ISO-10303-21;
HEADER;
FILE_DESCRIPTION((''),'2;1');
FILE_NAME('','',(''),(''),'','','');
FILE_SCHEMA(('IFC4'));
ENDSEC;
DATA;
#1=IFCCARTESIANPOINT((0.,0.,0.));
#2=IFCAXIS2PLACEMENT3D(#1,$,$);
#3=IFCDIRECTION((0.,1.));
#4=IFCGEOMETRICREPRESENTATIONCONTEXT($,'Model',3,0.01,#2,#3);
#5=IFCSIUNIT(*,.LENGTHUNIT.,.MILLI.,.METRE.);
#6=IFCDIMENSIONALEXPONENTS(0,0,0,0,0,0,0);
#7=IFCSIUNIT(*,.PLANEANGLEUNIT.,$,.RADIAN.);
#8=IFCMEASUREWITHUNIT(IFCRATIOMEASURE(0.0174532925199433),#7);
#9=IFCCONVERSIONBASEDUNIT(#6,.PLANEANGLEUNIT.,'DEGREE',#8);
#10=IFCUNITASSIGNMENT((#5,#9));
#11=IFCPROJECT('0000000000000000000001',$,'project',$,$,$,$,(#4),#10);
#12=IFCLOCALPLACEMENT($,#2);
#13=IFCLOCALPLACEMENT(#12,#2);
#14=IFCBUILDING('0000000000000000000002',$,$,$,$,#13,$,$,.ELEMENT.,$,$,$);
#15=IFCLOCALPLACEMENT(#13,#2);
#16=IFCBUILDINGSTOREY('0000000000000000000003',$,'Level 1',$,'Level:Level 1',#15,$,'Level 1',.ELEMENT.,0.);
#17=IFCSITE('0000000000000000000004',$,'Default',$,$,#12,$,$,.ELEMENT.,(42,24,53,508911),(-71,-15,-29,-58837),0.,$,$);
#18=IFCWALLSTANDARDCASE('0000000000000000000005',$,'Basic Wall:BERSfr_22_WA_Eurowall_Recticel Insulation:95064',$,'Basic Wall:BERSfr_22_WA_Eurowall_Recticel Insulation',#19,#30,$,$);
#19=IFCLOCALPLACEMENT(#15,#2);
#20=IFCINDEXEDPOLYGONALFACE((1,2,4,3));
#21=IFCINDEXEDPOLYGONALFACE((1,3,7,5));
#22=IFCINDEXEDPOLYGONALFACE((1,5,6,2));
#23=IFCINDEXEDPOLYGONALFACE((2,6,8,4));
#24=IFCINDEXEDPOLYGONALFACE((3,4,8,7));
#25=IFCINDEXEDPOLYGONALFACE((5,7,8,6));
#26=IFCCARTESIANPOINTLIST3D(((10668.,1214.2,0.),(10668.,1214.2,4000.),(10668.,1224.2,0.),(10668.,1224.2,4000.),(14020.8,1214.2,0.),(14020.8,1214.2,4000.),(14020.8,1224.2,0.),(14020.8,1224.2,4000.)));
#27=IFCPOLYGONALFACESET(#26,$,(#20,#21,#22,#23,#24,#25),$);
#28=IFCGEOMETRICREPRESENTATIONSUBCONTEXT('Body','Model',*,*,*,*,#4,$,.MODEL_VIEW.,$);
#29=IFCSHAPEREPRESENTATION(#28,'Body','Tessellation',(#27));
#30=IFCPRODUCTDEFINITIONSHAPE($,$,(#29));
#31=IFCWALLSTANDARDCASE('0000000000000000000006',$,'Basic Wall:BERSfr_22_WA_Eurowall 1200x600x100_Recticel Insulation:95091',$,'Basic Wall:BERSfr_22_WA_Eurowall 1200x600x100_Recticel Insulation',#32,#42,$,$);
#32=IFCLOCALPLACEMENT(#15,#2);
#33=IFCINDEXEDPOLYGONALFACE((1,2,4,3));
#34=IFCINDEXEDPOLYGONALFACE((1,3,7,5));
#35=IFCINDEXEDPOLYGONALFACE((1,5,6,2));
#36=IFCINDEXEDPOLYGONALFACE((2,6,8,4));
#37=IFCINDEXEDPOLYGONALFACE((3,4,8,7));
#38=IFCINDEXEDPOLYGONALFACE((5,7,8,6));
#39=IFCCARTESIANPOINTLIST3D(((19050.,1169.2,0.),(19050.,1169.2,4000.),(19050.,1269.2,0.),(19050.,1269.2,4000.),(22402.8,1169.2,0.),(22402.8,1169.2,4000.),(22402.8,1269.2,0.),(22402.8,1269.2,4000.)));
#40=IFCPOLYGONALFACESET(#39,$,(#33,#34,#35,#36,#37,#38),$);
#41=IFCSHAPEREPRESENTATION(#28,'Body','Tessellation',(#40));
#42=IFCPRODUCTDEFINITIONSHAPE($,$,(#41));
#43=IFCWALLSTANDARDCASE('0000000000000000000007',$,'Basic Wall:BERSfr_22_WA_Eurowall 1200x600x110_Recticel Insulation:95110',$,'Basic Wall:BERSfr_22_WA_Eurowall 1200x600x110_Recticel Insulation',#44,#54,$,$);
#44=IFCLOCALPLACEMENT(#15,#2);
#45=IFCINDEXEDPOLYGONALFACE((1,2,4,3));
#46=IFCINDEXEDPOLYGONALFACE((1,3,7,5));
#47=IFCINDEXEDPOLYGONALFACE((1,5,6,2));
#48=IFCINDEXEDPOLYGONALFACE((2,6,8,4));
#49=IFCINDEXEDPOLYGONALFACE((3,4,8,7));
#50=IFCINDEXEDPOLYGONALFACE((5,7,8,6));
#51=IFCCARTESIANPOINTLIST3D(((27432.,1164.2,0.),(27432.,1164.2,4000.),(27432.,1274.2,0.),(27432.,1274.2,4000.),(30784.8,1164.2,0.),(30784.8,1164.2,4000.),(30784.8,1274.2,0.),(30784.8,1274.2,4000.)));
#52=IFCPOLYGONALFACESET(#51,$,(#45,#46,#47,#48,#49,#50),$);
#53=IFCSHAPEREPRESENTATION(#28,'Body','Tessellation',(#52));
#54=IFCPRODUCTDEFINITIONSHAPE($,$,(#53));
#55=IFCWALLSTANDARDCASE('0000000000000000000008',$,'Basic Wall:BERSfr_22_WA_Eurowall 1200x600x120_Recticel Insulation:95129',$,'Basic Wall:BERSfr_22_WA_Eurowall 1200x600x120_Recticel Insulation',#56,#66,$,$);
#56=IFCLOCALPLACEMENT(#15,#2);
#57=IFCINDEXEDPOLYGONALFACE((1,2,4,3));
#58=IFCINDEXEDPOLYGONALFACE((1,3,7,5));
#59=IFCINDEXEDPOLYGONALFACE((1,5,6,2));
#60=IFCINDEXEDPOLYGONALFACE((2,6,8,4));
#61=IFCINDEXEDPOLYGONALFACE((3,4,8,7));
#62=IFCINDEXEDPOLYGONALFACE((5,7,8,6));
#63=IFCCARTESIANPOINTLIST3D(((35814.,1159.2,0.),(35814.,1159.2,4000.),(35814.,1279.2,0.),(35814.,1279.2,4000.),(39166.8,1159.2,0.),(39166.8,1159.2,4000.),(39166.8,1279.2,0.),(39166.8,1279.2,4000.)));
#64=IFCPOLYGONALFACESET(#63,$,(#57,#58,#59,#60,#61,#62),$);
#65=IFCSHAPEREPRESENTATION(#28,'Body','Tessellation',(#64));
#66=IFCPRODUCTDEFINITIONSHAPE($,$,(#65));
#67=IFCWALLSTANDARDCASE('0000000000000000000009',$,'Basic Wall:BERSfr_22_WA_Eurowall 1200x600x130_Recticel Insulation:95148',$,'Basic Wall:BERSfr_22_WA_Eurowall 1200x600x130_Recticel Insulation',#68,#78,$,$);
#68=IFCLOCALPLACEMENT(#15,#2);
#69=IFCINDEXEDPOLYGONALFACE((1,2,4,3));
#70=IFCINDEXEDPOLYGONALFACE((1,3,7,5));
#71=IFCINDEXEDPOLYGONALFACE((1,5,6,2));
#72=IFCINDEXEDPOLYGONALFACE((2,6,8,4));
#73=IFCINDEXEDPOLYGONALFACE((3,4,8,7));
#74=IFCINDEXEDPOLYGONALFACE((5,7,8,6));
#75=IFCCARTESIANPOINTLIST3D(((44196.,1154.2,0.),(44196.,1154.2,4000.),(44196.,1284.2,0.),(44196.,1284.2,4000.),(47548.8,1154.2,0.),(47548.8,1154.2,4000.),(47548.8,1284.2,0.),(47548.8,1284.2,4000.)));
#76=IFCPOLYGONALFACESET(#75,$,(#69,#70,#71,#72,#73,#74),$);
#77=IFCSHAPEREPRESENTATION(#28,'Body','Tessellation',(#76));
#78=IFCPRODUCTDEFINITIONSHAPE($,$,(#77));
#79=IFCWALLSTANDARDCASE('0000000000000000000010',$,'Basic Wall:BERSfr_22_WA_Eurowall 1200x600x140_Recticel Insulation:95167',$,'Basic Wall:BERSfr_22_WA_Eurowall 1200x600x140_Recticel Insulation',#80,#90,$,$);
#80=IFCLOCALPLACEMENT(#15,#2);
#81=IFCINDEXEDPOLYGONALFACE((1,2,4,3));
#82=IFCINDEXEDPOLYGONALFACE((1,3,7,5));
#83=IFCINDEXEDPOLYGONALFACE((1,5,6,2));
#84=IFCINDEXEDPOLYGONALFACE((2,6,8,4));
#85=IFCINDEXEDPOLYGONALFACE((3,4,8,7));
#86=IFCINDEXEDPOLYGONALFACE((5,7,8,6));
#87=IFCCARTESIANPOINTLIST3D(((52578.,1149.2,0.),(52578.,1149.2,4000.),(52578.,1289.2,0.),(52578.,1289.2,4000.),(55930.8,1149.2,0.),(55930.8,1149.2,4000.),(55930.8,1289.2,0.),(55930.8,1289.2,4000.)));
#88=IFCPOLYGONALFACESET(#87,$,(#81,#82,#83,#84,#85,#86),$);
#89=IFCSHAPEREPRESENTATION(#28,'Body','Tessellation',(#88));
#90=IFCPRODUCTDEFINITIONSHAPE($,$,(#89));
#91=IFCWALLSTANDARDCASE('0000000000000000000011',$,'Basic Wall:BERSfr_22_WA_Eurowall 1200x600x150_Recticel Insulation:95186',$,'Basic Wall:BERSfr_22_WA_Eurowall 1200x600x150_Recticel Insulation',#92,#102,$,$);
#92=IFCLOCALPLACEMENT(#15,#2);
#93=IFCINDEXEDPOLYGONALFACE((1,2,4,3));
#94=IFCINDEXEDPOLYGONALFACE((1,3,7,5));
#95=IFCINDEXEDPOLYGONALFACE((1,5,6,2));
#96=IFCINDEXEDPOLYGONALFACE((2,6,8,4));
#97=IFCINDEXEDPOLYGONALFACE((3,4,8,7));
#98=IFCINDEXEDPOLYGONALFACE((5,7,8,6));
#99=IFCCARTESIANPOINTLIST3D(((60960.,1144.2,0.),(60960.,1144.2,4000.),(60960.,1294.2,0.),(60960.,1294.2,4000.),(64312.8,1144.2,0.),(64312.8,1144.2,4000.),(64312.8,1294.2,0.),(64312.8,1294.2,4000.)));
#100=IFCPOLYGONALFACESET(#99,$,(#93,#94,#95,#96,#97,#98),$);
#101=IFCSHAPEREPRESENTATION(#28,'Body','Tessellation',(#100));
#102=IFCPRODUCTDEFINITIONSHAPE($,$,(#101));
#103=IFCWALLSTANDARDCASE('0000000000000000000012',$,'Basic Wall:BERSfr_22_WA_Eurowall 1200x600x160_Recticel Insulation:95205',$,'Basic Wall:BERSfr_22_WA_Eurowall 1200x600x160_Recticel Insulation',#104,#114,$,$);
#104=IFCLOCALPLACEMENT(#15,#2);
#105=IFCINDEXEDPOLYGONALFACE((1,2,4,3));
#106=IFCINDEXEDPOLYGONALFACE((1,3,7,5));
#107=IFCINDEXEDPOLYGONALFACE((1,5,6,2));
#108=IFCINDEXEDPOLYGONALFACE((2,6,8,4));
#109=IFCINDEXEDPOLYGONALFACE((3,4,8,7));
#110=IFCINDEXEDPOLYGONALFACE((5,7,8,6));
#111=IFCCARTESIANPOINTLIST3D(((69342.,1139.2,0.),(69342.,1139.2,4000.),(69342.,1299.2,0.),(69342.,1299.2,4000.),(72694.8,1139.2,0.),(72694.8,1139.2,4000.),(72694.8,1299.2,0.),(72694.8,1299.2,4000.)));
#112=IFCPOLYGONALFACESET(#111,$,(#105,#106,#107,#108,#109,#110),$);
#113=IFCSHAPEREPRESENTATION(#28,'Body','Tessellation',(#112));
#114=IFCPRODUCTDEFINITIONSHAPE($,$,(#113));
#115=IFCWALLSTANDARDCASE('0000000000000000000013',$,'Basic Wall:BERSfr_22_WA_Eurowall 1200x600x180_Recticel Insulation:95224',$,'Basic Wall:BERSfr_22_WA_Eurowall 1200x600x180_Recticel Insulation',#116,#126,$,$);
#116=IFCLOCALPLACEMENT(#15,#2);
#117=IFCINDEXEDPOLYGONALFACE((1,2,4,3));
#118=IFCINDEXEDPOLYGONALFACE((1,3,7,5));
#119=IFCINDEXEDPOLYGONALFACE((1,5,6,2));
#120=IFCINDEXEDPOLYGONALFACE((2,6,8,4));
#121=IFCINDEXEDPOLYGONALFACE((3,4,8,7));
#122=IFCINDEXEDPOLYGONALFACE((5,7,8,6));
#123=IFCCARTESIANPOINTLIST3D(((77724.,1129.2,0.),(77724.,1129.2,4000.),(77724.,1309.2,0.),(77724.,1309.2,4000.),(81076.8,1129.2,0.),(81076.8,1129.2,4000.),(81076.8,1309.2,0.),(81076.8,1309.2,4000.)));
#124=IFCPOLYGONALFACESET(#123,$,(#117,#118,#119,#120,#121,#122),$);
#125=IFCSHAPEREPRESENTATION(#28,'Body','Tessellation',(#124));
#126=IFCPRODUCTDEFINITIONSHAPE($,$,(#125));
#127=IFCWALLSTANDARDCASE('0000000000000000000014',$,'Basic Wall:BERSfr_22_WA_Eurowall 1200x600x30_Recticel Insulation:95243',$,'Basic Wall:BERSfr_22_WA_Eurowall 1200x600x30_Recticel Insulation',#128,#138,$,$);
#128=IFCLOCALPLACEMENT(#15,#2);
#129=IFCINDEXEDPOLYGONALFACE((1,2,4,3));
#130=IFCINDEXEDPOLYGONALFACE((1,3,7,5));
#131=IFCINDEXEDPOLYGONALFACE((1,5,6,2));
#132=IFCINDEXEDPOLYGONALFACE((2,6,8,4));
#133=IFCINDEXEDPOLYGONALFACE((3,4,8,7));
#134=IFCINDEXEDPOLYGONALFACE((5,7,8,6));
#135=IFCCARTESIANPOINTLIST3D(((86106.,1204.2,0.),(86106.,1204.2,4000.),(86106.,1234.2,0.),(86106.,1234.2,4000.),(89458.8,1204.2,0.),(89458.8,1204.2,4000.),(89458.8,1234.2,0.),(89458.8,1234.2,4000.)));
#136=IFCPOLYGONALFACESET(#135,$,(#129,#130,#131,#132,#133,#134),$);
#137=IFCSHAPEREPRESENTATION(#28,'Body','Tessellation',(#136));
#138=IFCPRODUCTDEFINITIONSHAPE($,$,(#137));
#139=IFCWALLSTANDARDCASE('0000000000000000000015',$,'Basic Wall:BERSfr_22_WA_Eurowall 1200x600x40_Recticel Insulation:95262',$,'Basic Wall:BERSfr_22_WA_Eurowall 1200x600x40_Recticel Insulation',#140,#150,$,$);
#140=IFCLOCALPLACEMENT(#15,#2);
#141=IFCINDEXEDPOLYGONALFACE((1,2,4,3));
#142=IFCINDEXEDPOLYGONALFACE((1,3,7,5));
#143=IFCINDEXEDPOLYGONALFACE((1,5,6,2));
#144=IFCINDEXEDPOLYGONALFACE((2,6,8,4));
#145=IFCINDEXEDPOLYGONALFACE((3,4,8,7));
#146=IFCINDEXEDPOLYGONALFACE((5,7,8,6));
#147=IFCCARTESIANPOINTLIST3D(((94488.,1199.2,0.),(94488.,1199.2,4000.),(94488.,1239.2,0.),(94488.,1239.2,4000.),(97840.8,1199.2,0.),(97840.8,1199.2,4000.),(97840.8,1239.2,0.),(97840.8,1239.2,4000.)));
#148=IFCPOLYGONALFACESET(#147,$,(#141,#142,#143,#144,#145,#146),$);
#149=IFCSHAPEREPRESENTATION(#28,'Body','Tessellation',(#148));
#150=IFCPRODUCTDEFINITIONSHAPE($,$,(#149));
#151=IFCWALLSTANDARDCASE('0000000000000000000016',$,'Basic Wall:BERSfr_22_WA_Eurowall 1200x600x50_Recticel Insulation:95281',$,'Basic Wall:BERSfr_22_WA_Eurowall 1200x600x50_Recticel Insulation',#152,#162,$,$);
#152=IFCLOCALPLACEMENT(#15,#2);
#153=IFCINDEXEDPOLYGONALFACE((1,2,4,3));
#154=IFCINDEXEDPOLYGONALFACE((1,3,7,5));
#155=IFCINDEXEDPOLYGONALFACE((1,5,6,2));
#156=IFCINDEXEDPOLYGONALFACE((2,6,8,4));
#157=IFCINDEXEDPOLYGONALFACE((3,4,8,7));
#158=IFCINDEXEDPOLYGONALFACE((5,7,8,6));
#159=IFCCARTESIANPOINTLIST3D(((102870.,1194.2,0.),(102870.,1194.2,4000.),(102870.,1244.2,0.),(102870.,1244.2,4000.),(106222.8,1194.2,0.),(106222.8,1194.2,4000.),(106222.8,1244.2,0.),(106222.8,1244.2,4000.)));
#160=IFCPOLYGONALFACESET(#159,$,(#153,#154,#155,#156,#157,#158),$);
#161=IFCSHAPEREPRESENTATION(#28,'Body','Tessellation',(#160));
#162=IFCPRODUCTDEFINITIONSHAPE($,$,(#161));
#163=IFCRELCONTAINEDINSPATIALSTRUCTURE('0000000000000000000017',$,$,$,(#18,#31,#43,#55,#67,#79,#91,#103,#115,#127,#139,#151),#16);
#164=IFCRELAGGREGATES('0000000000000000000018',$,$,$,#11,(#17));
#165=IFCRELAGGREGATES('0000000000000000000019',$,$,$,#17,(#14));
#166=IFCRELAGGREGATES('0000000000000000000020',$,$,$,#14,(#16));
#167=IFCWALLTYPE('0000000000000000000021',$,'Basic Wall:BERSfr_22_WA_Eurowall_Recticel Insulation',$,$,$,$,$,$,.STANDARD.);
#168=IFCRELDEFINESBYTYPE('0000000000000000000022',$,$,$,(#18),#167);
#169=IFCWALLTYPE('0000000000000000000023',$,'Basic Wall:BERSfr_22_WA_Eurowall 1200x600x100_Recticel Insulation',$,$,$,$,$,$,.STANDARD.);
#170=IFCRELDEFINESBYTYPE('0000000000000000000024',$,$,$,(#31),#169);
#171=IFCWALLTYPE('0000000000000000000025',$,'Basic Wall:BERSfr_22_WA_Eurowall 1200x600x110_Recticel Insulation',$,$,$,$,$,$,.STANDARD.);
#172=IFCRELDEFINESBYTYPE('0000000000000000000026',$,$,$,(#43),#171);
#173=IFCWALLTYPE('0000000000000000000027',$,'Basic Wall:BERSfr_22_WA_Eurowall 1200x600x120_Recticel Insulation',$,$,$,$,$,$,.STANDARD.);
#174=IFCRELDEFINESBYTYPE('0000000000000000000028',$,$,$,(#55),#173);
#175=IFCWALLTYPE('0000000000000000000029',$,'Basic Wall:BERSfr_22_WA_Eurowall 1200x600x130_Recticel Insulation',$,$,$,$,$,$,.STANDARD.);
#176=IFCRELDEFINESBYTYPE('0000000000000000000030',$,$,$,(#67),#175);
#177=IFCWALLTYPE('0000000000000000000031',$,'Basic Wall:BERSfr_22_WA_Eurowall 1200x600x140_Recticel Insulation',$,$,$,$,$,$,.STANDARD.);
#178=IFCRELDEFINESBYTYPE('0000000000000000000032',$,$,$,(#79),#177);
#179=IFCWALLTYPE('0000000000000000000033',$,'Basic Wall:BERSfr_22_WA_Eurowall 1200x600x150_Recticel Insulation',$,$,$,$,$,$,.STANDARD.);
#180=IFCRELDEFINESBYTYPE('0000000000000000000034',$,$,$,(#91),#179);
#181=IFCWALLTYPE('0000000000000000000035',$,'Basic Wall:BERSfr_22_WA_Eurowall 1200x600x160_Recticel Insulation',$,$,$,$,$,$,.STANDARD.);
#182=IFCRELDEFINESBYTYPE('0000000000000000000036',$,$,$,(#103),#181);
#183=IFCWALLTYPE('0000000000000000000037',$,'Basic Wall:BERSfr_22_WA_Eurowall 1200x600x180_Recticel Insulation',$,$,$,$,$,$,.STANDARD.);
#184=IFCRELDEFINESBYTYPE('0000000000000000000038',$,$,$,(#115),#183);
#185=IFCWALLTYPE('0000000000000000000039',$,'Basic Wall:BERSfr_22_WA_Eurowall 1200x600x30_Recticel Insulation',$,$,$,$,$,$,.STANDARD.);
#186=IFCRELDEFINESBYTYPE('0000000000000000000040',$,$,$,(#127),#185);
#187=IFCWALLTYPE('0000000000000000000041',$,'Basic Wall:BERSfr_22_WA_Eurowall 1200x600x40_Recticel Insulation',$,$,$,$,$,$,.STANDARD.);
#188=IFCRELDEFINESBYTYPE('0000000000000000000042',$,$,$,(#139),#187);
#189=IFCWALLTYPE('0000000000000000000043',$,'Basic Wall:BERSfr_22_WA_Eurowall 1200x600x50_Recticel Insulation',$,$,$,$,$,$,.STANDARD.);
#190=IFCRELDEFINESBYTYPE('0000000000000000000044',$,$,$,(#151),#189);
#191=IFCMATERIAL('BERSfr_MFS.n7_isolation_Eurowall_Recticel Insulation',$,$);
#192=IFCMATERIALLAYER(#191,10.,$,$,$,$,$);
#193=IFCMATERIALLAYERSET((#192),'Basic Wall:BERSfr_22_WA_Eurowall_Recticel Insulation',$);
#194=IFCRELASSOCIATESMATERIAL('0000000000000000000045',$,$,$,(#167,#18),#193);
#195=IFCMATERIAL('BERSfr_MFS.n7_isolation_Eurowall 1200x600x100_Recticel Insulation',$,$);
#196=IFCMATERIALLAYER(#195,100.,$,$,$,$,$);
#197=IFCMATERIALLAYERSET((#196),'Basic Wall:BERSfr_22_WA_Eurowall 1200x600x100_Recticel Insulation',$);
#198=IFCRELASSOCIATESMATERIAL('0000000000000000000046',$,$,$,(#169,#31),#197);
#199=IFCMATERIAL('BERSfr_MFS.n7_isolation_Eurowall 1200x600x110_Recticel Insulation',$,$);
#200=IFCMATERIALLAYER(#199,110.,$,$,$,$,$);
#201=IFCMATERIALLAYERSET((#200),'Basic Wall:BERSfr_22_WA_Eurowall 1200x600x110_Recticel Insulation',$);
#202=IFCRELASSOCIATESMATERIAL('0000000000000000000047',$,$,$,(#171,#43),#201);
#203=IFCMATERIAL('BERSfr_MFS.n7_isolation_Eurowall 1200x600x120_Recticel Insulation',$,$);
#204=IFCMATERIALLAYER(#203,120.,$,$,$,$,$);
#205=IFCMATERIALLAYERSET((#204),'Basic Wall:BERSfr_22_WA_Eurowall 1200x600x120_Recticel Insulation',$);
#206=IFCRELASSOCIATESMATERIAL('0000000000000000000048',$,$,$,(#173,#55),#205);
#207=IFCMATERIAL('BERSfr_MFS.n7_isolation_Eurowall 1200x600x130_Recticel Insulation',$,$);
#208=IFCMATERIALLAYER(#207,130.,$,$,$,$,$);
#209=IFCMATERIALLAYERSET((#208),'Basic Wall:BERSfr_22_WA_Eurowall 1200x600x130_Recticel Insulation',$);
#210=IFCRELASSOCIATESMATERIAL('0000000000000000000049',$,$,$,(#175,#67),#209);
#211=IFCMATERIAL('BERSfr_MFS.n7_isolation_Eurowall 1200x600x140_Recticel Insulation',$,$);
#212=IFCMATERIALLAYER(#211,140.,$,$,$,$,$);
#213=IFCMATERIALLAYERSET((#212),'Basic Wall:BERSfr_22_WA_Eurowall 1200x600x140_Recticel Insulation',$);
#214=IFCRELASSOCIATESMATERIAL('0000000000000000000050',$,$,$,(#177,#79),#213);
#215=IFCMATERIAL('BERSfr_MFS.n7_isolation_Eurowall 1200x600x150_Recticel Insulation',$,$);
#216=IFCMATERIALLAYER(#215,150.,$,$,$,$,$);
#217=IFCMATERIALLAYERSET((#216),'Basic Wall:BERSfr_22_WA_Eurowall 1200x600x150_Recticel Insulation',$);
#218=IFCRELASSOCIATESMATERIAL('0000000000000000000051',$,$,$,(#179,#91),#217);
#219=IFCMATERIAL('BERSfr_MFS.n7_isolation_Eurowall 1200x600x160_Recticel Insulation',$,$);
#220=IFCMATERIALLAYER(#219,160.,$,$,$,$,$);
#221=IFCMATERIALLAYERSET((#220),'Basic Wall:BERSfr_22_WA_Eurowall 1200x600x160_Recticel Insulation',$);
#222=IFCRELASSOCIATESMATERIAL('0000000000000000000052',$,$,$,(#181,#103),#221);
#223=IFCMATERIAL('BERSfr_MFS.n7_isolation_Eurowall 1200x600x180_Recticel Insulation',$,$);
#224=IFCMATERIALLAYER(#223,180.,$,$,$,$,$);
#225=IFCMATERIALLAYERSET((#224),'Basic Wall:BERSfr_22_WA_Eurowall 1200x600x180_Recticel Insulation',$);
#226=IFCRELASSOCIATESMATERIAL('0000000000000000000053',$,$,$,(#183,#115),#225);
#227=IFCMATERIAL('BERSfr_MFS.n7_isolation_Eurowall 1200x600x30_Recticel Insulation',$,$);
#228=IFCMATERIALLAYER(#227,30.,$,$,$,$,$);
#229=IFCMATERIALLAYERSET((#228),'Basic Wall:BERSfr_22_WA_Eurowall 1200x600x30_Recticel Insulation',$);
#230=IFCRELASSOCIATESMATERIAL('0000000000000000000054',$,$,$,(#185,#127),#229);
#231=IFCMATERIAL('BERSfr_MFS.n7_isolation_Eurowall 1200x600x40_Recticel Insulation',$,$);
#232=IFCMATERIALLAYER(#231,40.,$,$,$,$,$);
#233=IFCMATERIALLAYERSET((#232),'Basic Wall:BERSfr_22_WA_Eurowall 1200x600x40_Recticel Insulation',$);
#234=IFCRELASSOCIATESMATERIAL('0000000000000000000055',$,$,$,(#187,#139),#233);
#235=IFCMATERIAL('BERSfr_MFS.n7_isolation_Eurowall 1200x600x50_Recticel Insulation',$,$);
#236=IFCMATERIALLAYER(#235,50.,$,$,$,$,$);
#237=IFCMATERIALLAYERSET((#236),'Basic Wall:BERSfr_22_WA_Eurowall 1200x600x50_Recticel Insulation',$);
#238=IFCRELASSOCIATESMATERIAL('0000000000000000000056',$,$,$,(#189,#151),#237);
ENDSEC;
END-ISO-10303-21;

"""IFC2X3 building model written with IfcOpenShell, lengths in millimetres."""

from ifc_helpers import new_model, entity, si_unit, converted_unit, direction, frame, frame_2d, origin, place, context, subcontext, project, spatial, rectangle, extrude, material, layer, layer_set, layer_usage, type_object, element, save


model = new_model("IFC2X3")

# Units and contexts
model_context = context("Model", 3, precision=0.01, world=origin(), true_north=direction((0.0, 1.0)))
body_context = subcontext(model_context, "Body", "Model", "MODEL_VIEW")
ifc_project = project(units=[si_unit("LENGTHUNIT", "METRE", prefix="MILLI"), converted_unit("PLANEANGLEUNIT", "DEGREE", entity("IfcRatioMeasure", 0.0174532925199433), si_unit("PLANEANGLEUNIT", "RADIAN"), dimensions=[0, 0, 0, 0, 0, 0, 0])], contexts=[model_context])

# Site, building, storey
site_placement = place(None, origin())
site = spatial("IfcSite", under=ifc_project, at=site_placement, Name="Default", CompositionType="ELEMENT", RefLatitude=(42, 24, 53, 508911), RefLongitude=(-71, -15, -29, -58837), RefElevation=0.0)
building_placement = place(site_placement, origin())
building = spatial("IfcBuilding", under=site, at=building_placement, CompositionType="ELEMENT")
storey_placement = place(building_placement, origin())
storey = spatial("IfcBuildingStorey", under=building, at=storey_placement, Name="Level 1", ObjectType="Level:Level 1", LongName="Level 1", CompositionType="ELEMENT", Elevation=0.0)

# Walls
ifc_material_1 = material(Name="BERSfr_MFS.n7_isolation_Eurowall_Recticel Insulation")
ifc_layer_1 = layer(ifc_material_1, 10.0)
ifc_layer_set_1 = layer_set([ifc_layer_1], Name="Basic Wall:BERSfr_22_WA_Eurowall_Recticel Insulation")
ifc_layer_usage_1 = layer_usage(ifc_layer_set_1, "AXIS2", "NEGATIVE", 5.0)
wall_type_1 = type_object("IfcWallType", Name="Basic Wall:BERSfr_22_WA_Eurowall_Recticel Insulation", PredefinedType="STANDARD", material=ifc_layer_set_1)
wall_1_placement = place(storey_placement, frame((10668.0, 1219.2, 0.0)))
element("IfcWallStandardCase", 1, at=wall_1_placement, inside=storey, type_object=wall_type_1, material=ifc_layer_usage_1, Name="Basic Wall:BERSfr_22_WA_Eurowall_Recticel Insulation:95064", ObjectType="Basic Wall:BERSfr_22_WA_Eurowall_Recticel Insulation", context=body_context, shape_type="SweptSolid", body=[
    extrude(rectangle(XDim=3352.8, YDim=10.0, at=frame_2d((1676.4, 0.0), x_axis=(-1.0, 0.0))), origin(), (0.0, 0.0, 1.0), 4000.0),
])
ifc_material_2 = material(Name="BERSfr_MFS.n7_isolation_Eurowall 1200x600x100_Recticel Insulation")
ifc_layer_2 = layer(ifc_material_2, 100.0)
ifc_layer_set_2 = layer_set([ifc_layer_2], Name="Basic Wall:BERSfr_22_WA_Eurowall 1200x600x100_Recticel Insulation")
ifc_layer_usage_2 = layer_usage(ifc_layer_set_2, "AXIS2", "NEGATIVE", 50.0)
wall_type_2 = type_object("IfcWallType", Name="Basic Wall:BERSfr_22_WA_Eurowall 1200x600x100_Recticel Insulation", PredefinedType="STANDARD", material=ifc_layer_set_2)
wall_2_placement = place(storey_placement, frame((19050.0, 1219.2, 0.0)))
element("IfcWallStandardCase", 2, at=wall_2_placement, inside=storey, type_object=wall_type_2, material=ifc_layer_usage_2, Name="Basic Wall:BERSfr_22_WA_Eurowall 1200x600x100_Recticel Insulation:95091", ObjectType="Basic Wall:BERSfr_22_WA_Eurowall 1200x600x100_Recticel Insulation", context=body_context, shape_type="SweptSolid", body=[
    extrude(rectangle(XDim=3352.8, YDim=100.0, at=frame_2d((1676.4, 0.0), x_axis=(-1.0, 0.0))), origin(), (0.0, 0.0, 1.0), 4000.0),
])
ifc_material_3 = material(Name="BERSfr_MFS.n7_isolation_Eurowall 1200x600x110_Recticel Insulation")
ifc_layer_3 = layer(ifc_material_3, 110.0)
ifc_layer_set_3 = layer_set([ifc_layer_3], Name="Basic Wall:BERSfr_22_WA_Eurowall 1200x600x110_Recticel Insulation")
ifc_layer_usage_3 = layer_usage(ifc_layer_set_3, "AXIS2", "NEGATIVE", 55.0)
wall_type_3 = type_object("IfcWallType", Name="Basic Wall:BERSfr_22_WA_Eurowall 1200x600x110_Recticel Insulation", PredefinedType="STANDARD", material=ifc_layer_set_3)
wall_3_placement = place(storey_placement, frame((27432.0, 1219.2, 0.0)))
element("IfcWallStandardCase", 3, at=wall_3_placement, inside=storey, type_object=wall_type_3, material=ifc_layer_usage_3, Name="Basic Wall:BERSfr_22_WA_Eurowall 1200x600x110_Recticel Insulation:95110", ObjectType="Basic Wall:BERSfr_22_WA_Eurowall 1200x600x110_Recticel Insulation", context=body_context, shape_type="SweptSolid", body=[
    extrude(rectangle(XDim=3352.8, YDim=110.0, at=frame_2d((1676.4, 0.0), x_axis=(-1.0, 0.0))), origin(), (0.0, 0.0, 1.0), 4000.0),
])
ifc_material_4 = material(Name="BERSfr_MFS.n7_isolation_Eurowall 1200x600x120_Recticel Insulation")
ifc_layer_4 = layer(ifc_material_4, 120.0)
ifc_layer_set_4 = layer_set([ifc_layer_4], Name="Basic Wall:BERSfr_22_WA_Eurowall 1200x600x120_Recticel Insulation")
ifc_layer_usage_4 = layer_usage(ifc_layer_set_4, "AXIS2", "NEGATIVE", 60.0)
wall_type_4 = type_object("IfcWallType", Name="Basic Wall:BERSfr_22_WA_Eurowall 1200x600x120_Recticel Insulation", PredefinedType="STANDARD", material=ifc_layer_set_4)
wall_4_placement = place(storey_placement, frame((35814.0, 1219.2, 0.0)))
element("IfcWallStandardCase", 4, at=wall_4_placement, inside=storey, type_object=wall_type_4, material=ifc_layer_usage_4, Name="Basic Wall:BERSfr_22_WA_Eurowall 1200x600x120_Recticel Insulation:95129", ObjectType="Basic Wall:BERSfr_22_WA_Eurowall 1200x600x120_Recticel Insulation", context=body_context, shape_type="SweptSolid", body=[
    extrude(rectangle(XDim=3352.8, YDim=120.0, at=frame_2d((1676.4, 0.0), x_axis=(-1.0, 0.0))), origin(), (0.0, 0.0, 1.0), 4000.0),
])
ifc_material_5 = material(Name="BERSfr_MFS.n7_isolation_Eurowall 1200x600x130_Recticel Insulation")
ifc_layer_5 = layer(ifc_material_5, 130.0)
ifc_layer_set_5 = layer_set([ifc_layer_5], Name="Basic Wall:BERSfr_22_WA_Eurowall 1200x600x130_Recticel Insulation")
ifc_layer_usage_5 = layer_usage(ifc_layer_set_5, "AXIS2", "NEGATIVE", 65.0)
wall_type_5 = type_object("IfcWallType", Name="Basic Wall:BERSfr_22_WA_Eurowall 1200x600x130_Recticel Insulation", PredefinedType="STANDARD", material=ifc_layer_set_5)
wall_5_placement = place(storey_placement, frame((44196.0, 1219.2, 0.0)))
element("IfcWallStandardCase", 5, at=wall_5_placement, inside=storey, type_object=wall_type_5, material=ifc_layer_usage_5, Name="Basic Wall:BERSfr_22_WA_Eurowall 1200x600x130_Recticel Insulation:95148", ObjectType="Basic Wall:BERSfr_22_WA_Eurowall 1200x600x130_Recticel Insulation", context=body_context, shape_type="SweptSolid", body=[
    extrude(rectangle(XDim=3352.8, YDim=130.0, at=frame_2d((1676.4, 0.0), x_axis=(-1.0, 0.0))), origin(), (0.0, 0.0, 1.0), 4000.0),
])
ifc_material_6 = material(Name="BERSfr_MFS.n7_isolation_Eurowall 1200x600x140_Recticel Insulation")
ifc_layer_6 = layer(ifc_material_6, 140.0)
ifc_layer_set_6 = layer_set([ifc_layer_6], Name="Basic Wall:BERSfr_22_WA_Eurowall 1200x600x140_Recticel Insulation")
ifc_layer_usage_6 = layer_usage(ifc_layer_set_6, "AXIS2", "NEGATIVE", 70.0)
wall_type_6 = type_object("IfcWallType", Name="Basic Wall:BERSfr_22_WA_Eurowall 1200x600x140_Recticel Insulation", PredefinedType="STANDARD", material=ifc_layer_set_6)
wall_6_placement = place(storey_placement, frame((52578.0, 1219.2, 0.0)))
element("IfcWallStandardCase", 6, at=wall_6_placement, inside=storey, type_object=wall_type_6, material=ifc_layer_usage_6, Name="Basic Wall:BERSfr_22_WA_Eurowall 1200x600x140_Recticel Insulation:95167", ObjectType="Basic Wall:BERSfr_22_WA_Eurowall 1200x600x140_Recticel Insulation", context=body_context, shape_type="SweptSolid", body=[
    extrude(rectangle(XDim=3352.8, YDim=140.0, at=frame_2d((1676.4, 0.0), x_axis=(-1.0, 0.0))), origin(), (0.0, 0.0, 1.0), 4000.0),
])
ifc_material_7 = material(Name="BERSfr_MFS.n7_isolation_Eurowall 1200x600x150_Recticel Insulation")
ifc_layer_7 = layer(ifc_material_7, 150.0)
ifc_layer_set_7 = layer_set([ifc_layer_7], Name="Basic Wall:BERSfr_22_WA_Eurowall 1200x600x150_Recticel Insulation")
ifc_layer_usage_7 = layer_usage(ifc_layer_set_7, "AXIS2", "NEGATIVE", 75.0)
wall_type_7 = type_object("IfcWallType", Name="Basic Wall:BERSfr_22_WA_Eurowall 1200x600x150_Recticel Insulation", PredefinedType="STANDARD", material=ifc_layer_set_7)
wall_7_placement = place(storey_placement, frame((60960.0, 1219.2, 0.0)))
element("IfcWallStandardCase", 7, at=wall_7_placement, inside=storey, type_object=wall_type_7, material=ifc_layer_usage_7, Name="Basic Wall:BERSfr_22_WA_Eurowall 1200x600x150_Recticel Insulation:95186", ObjectType="Basic Wall:BERSfr_22_WA_Eurowall 1200x600x150_Recticel Insulation", context=body_context, shape_type="SweptSolid", body=[
    extrude(rectangle(XDim=3352.8, YDim=150.0, at=frame_2d((1676.4, 0.0), x_axis=(-1.0, 0.0))), origin(), (0.0, 0.0, 1.0), 4000.0),
])
ifc_material_8 = material(Name="BERSfr_MFS.n7_isolation_Eurowall 1200x600x160_Recticel Insulation")
ifc_layer_8 = layer(ifc_material_8, 160.0)
ifc_layer_set_8 = layer_set([ifc_layer_8], Name="Basic Wall:BERSfr_22_WA_Eurowall 1200x600x160_Recticel Insulation")
ifc_layer_usage_8 = layer_usage(ifc_layer_set_8, "AXIS2", "NEGATIVE", 80.0)
wall_type_8 = type_object("IfcWallType", Name="Basic Wall:BERSfr_22_WA_Eurowall 1200x600x160_Recticel Insulation", PredefinedType="STANDARD", material=ifc_layer_set_8)
wall_8_placement = place(storey_placement, frame((69342.0, 1219.2, 0.0)))
element("IfcWallStandardCase", 8, at=wall_8_placement, inside=storey, type_object=wall_type_8, material=ifc_layer_usage_8, Name="Basic Wall:BERSfr_22_WA_Eurowall 1200x600x160_Recticel Insulation:95205", ObjectType="Basic Wall:BERSfr_22_WA_Eurowall 1200x600x160_Recticel Insulation", context=body_context, shape_type="SweptSolid", body=[
    extrude(rectangle(XDim=3352.8, YDim=160.0, at=frame_2d((1676.4, 0.0), x_axis=(-1.0, 0.0))), origin(), (0.0, 0.0, 1.0), 4000.0),
])
ifc_material_9 = material(Name="BERSfr_MFS.n7_isolation_Eurowall 1200x600x180_Recticel Insulation")
ifc_layer_9 = layer(ifc_material_9, 180.0)
ifc_layer_set_9 = layer_set([ifc_layer_9], Name="Basic Wall:BERSfr_22_WA_Eurowall 1200x600x180_Recticel Insulation")
ifc_layer_usage_9 = layer_usage(ifc_layer_set_9, "AXIS2", "NEGATIVE", 90.0)
wall_type_9 = type_object("IfcWallType", Name="Basic Wall:BERSfr_22_WA_Eurowall 1200x600x180_Recticel Insulation", PredefinedType="STANDARD", material=ifc_layer_set_9)
wall_9_placement = place(storey_placement, frame((77724.0, 1219.2, 0.0)))
element("IfcWallStandardCase", 9, at=wall_9_placement, inside=storey, type_object=wall_type_9, material=ifc_layer_usage_9, Name="Basic Wall:BERSfr_22_WA_Eurowall 1200x600x180_Recticel Insulation:95224", ObjectType="Basic Wall:BERSfr_22_WA_Eurowall 1200x600x180_Recticel Insulation", context=body_context, shape_type="SweptSolid", body=[
    extrude(rectangle(XDim=3352.8, YDim=180.0, at=frame_2d((1676.4, 0.0), x_axis=(-1.0, 0.0))), origin(), (0.0, 0.0, 1.0), 4000.0),
])
ifc_material_10 = material(Name="BERSfr_MFS.n7_isolation_Eurowall 1200x600x30_Recticel Insulation")
ifc_layer_10 = layer(ifc_material_10, 30.0)
ifc_layer_set_10 = layer_set([ifc_layer_10], Name="Basic Wall:BERSfr_22_WA_Eurowall 1200x600x30_Recticel Insulation")
ifc_layer_usage_10 = layer_usage(ifc_layer_set_10, "AXIS2", "NEGATIVE", 15.0)
wall_type_10 = type_object("IfcWallType", Name="Basic Wall:BERSfr_22_WA_Eurowall 1200x600x30_Recticel Insulation", PredefinedType="STANDARD", material=ifc_layer_set_10)
wall_10_placement = place(storey_placement, frame((86106.0, 1219.2, 0.0)))
element("IfcWallStandardCase", 10, at=wall_10_placement, inside=storey, type_object=wall_type_10, material=ifc_layer_usage_10, Name="Basic Wall:BERSfr_22_WA_Eurowall 1200x600x30_Recticel Insulation:95243", ObjectType="Basic Wall:BERSfr_22_WA_Eurowall 1200x600x30_Recticel Insulation", context=body_context, shape_type="SweptSolid", body=[
    extrude(rectangle(XDim=3352.8, YDim=30.0, at=frame_2d((1676.4, 0.0), x_axis=(-1.0, 0.0))), origin(), (0.0, 0.0, 1.0), 4000.0),
])
ifc_material_11 = material(Name="BERSfr_MFS.n7_isolation_Eurowall 1200x600x40_Recticel Insulation")
ifc_layer_11 = layer(ifc_material_11, 40.0)
ifc_layer_set_11 = layer_set([ifc_layer_11], Name="Basic Wall:BERSfr_22_WA_Eurowall 1200x600x40_Recticel Insulation")
ifc_layer_usage_11 = layer_usage(ifc_layer_set_11, "AXIS2", "NEGATIVE", 20.0)
wall_type_11 = type_object("IfcWallType", Name="Basic Wall:BERSfr_22_WA_Eurowall 1200x600x40_Recticel Insulation", PredefinedType="STANDARD", material=ifc_layer_set_11)
wall_11_placement = place(storey_placement, frame((94488.0, 1219.2, 0.0)))
element("IfcWallStandardCase", 11, at=wall_11_placement, inside=storey, type_object=wall_type_11, material=ifc_layer_usage_11, Name="Basic Wall:BERSfr_22_WA_Eurowall 1200x600x40_Recticel Insulation:95262", ObjectType="Basic Wall:BERSfr_22_WA_Eurowall 1200x600x40_Recticel Insulation", context=body_context, shape_type="SweptSolid", body=[
    extrude(rectangle(XDim=3352.8, YDim=40.0, at=frame_2d((1676.4, 0.0), x_axis=(-1.0, 0.0))), origin(), (0.0, 0.0, 1.0), 4000.0),
])
ifc_material_12 = material(Name="BERSfr_MFS.n7_isolation_Eurowall 1200x600x50_Recticel Insulation")
ifc_layer_12 = layer(ifc_material_12, 50.0)
ifc_layer_set_12 = layer_set([ifc_layer_12], Name="Basic Wall:BERSfr_22_WA_Eurowall 1200x600x50_Recticel Insulation")
ifc_layer_usage_12 = layer_usage(ifc_layer_set_12, "AXIS2", "NEGATIVE", 25.0)
wall_type_12 = type_object("IfcWallType", Name="Basic Wall:BERSfr_22_WA_Eurowall 1200x600x50_Recticel Insulation", PredefinedType="STANDARD", material=ifc_layer_set_12)
wall_12_placement = place(storey_placement, frame((102870.0, 1219.2, 0.0)))
element("IfcWallStandardCase", 12, at=wall_12_placement, inside=storey, type_object=wall_type_12, material=ifc_layer_usage_12, Name="Basic Wall:BERSfr_22_WA_Eurowall 1200x600x50_Recticel Insulation:95281", ObjectType="Basic Wall:BERSfr_22_WA_Eurowall 1200x600x50_Recticel Insulation", context=body_context, shape_type="SweptSolid", body=[
    extrude(rectangle(XDim=3352.8, YDim=50.0, at=frame_2d((1676.4, 0.0), x_axis=(-1.0, 0.0))), origin(), (0.0, 0.0, 1.0), 4000.0),
])

save(model, "model.ifc")
